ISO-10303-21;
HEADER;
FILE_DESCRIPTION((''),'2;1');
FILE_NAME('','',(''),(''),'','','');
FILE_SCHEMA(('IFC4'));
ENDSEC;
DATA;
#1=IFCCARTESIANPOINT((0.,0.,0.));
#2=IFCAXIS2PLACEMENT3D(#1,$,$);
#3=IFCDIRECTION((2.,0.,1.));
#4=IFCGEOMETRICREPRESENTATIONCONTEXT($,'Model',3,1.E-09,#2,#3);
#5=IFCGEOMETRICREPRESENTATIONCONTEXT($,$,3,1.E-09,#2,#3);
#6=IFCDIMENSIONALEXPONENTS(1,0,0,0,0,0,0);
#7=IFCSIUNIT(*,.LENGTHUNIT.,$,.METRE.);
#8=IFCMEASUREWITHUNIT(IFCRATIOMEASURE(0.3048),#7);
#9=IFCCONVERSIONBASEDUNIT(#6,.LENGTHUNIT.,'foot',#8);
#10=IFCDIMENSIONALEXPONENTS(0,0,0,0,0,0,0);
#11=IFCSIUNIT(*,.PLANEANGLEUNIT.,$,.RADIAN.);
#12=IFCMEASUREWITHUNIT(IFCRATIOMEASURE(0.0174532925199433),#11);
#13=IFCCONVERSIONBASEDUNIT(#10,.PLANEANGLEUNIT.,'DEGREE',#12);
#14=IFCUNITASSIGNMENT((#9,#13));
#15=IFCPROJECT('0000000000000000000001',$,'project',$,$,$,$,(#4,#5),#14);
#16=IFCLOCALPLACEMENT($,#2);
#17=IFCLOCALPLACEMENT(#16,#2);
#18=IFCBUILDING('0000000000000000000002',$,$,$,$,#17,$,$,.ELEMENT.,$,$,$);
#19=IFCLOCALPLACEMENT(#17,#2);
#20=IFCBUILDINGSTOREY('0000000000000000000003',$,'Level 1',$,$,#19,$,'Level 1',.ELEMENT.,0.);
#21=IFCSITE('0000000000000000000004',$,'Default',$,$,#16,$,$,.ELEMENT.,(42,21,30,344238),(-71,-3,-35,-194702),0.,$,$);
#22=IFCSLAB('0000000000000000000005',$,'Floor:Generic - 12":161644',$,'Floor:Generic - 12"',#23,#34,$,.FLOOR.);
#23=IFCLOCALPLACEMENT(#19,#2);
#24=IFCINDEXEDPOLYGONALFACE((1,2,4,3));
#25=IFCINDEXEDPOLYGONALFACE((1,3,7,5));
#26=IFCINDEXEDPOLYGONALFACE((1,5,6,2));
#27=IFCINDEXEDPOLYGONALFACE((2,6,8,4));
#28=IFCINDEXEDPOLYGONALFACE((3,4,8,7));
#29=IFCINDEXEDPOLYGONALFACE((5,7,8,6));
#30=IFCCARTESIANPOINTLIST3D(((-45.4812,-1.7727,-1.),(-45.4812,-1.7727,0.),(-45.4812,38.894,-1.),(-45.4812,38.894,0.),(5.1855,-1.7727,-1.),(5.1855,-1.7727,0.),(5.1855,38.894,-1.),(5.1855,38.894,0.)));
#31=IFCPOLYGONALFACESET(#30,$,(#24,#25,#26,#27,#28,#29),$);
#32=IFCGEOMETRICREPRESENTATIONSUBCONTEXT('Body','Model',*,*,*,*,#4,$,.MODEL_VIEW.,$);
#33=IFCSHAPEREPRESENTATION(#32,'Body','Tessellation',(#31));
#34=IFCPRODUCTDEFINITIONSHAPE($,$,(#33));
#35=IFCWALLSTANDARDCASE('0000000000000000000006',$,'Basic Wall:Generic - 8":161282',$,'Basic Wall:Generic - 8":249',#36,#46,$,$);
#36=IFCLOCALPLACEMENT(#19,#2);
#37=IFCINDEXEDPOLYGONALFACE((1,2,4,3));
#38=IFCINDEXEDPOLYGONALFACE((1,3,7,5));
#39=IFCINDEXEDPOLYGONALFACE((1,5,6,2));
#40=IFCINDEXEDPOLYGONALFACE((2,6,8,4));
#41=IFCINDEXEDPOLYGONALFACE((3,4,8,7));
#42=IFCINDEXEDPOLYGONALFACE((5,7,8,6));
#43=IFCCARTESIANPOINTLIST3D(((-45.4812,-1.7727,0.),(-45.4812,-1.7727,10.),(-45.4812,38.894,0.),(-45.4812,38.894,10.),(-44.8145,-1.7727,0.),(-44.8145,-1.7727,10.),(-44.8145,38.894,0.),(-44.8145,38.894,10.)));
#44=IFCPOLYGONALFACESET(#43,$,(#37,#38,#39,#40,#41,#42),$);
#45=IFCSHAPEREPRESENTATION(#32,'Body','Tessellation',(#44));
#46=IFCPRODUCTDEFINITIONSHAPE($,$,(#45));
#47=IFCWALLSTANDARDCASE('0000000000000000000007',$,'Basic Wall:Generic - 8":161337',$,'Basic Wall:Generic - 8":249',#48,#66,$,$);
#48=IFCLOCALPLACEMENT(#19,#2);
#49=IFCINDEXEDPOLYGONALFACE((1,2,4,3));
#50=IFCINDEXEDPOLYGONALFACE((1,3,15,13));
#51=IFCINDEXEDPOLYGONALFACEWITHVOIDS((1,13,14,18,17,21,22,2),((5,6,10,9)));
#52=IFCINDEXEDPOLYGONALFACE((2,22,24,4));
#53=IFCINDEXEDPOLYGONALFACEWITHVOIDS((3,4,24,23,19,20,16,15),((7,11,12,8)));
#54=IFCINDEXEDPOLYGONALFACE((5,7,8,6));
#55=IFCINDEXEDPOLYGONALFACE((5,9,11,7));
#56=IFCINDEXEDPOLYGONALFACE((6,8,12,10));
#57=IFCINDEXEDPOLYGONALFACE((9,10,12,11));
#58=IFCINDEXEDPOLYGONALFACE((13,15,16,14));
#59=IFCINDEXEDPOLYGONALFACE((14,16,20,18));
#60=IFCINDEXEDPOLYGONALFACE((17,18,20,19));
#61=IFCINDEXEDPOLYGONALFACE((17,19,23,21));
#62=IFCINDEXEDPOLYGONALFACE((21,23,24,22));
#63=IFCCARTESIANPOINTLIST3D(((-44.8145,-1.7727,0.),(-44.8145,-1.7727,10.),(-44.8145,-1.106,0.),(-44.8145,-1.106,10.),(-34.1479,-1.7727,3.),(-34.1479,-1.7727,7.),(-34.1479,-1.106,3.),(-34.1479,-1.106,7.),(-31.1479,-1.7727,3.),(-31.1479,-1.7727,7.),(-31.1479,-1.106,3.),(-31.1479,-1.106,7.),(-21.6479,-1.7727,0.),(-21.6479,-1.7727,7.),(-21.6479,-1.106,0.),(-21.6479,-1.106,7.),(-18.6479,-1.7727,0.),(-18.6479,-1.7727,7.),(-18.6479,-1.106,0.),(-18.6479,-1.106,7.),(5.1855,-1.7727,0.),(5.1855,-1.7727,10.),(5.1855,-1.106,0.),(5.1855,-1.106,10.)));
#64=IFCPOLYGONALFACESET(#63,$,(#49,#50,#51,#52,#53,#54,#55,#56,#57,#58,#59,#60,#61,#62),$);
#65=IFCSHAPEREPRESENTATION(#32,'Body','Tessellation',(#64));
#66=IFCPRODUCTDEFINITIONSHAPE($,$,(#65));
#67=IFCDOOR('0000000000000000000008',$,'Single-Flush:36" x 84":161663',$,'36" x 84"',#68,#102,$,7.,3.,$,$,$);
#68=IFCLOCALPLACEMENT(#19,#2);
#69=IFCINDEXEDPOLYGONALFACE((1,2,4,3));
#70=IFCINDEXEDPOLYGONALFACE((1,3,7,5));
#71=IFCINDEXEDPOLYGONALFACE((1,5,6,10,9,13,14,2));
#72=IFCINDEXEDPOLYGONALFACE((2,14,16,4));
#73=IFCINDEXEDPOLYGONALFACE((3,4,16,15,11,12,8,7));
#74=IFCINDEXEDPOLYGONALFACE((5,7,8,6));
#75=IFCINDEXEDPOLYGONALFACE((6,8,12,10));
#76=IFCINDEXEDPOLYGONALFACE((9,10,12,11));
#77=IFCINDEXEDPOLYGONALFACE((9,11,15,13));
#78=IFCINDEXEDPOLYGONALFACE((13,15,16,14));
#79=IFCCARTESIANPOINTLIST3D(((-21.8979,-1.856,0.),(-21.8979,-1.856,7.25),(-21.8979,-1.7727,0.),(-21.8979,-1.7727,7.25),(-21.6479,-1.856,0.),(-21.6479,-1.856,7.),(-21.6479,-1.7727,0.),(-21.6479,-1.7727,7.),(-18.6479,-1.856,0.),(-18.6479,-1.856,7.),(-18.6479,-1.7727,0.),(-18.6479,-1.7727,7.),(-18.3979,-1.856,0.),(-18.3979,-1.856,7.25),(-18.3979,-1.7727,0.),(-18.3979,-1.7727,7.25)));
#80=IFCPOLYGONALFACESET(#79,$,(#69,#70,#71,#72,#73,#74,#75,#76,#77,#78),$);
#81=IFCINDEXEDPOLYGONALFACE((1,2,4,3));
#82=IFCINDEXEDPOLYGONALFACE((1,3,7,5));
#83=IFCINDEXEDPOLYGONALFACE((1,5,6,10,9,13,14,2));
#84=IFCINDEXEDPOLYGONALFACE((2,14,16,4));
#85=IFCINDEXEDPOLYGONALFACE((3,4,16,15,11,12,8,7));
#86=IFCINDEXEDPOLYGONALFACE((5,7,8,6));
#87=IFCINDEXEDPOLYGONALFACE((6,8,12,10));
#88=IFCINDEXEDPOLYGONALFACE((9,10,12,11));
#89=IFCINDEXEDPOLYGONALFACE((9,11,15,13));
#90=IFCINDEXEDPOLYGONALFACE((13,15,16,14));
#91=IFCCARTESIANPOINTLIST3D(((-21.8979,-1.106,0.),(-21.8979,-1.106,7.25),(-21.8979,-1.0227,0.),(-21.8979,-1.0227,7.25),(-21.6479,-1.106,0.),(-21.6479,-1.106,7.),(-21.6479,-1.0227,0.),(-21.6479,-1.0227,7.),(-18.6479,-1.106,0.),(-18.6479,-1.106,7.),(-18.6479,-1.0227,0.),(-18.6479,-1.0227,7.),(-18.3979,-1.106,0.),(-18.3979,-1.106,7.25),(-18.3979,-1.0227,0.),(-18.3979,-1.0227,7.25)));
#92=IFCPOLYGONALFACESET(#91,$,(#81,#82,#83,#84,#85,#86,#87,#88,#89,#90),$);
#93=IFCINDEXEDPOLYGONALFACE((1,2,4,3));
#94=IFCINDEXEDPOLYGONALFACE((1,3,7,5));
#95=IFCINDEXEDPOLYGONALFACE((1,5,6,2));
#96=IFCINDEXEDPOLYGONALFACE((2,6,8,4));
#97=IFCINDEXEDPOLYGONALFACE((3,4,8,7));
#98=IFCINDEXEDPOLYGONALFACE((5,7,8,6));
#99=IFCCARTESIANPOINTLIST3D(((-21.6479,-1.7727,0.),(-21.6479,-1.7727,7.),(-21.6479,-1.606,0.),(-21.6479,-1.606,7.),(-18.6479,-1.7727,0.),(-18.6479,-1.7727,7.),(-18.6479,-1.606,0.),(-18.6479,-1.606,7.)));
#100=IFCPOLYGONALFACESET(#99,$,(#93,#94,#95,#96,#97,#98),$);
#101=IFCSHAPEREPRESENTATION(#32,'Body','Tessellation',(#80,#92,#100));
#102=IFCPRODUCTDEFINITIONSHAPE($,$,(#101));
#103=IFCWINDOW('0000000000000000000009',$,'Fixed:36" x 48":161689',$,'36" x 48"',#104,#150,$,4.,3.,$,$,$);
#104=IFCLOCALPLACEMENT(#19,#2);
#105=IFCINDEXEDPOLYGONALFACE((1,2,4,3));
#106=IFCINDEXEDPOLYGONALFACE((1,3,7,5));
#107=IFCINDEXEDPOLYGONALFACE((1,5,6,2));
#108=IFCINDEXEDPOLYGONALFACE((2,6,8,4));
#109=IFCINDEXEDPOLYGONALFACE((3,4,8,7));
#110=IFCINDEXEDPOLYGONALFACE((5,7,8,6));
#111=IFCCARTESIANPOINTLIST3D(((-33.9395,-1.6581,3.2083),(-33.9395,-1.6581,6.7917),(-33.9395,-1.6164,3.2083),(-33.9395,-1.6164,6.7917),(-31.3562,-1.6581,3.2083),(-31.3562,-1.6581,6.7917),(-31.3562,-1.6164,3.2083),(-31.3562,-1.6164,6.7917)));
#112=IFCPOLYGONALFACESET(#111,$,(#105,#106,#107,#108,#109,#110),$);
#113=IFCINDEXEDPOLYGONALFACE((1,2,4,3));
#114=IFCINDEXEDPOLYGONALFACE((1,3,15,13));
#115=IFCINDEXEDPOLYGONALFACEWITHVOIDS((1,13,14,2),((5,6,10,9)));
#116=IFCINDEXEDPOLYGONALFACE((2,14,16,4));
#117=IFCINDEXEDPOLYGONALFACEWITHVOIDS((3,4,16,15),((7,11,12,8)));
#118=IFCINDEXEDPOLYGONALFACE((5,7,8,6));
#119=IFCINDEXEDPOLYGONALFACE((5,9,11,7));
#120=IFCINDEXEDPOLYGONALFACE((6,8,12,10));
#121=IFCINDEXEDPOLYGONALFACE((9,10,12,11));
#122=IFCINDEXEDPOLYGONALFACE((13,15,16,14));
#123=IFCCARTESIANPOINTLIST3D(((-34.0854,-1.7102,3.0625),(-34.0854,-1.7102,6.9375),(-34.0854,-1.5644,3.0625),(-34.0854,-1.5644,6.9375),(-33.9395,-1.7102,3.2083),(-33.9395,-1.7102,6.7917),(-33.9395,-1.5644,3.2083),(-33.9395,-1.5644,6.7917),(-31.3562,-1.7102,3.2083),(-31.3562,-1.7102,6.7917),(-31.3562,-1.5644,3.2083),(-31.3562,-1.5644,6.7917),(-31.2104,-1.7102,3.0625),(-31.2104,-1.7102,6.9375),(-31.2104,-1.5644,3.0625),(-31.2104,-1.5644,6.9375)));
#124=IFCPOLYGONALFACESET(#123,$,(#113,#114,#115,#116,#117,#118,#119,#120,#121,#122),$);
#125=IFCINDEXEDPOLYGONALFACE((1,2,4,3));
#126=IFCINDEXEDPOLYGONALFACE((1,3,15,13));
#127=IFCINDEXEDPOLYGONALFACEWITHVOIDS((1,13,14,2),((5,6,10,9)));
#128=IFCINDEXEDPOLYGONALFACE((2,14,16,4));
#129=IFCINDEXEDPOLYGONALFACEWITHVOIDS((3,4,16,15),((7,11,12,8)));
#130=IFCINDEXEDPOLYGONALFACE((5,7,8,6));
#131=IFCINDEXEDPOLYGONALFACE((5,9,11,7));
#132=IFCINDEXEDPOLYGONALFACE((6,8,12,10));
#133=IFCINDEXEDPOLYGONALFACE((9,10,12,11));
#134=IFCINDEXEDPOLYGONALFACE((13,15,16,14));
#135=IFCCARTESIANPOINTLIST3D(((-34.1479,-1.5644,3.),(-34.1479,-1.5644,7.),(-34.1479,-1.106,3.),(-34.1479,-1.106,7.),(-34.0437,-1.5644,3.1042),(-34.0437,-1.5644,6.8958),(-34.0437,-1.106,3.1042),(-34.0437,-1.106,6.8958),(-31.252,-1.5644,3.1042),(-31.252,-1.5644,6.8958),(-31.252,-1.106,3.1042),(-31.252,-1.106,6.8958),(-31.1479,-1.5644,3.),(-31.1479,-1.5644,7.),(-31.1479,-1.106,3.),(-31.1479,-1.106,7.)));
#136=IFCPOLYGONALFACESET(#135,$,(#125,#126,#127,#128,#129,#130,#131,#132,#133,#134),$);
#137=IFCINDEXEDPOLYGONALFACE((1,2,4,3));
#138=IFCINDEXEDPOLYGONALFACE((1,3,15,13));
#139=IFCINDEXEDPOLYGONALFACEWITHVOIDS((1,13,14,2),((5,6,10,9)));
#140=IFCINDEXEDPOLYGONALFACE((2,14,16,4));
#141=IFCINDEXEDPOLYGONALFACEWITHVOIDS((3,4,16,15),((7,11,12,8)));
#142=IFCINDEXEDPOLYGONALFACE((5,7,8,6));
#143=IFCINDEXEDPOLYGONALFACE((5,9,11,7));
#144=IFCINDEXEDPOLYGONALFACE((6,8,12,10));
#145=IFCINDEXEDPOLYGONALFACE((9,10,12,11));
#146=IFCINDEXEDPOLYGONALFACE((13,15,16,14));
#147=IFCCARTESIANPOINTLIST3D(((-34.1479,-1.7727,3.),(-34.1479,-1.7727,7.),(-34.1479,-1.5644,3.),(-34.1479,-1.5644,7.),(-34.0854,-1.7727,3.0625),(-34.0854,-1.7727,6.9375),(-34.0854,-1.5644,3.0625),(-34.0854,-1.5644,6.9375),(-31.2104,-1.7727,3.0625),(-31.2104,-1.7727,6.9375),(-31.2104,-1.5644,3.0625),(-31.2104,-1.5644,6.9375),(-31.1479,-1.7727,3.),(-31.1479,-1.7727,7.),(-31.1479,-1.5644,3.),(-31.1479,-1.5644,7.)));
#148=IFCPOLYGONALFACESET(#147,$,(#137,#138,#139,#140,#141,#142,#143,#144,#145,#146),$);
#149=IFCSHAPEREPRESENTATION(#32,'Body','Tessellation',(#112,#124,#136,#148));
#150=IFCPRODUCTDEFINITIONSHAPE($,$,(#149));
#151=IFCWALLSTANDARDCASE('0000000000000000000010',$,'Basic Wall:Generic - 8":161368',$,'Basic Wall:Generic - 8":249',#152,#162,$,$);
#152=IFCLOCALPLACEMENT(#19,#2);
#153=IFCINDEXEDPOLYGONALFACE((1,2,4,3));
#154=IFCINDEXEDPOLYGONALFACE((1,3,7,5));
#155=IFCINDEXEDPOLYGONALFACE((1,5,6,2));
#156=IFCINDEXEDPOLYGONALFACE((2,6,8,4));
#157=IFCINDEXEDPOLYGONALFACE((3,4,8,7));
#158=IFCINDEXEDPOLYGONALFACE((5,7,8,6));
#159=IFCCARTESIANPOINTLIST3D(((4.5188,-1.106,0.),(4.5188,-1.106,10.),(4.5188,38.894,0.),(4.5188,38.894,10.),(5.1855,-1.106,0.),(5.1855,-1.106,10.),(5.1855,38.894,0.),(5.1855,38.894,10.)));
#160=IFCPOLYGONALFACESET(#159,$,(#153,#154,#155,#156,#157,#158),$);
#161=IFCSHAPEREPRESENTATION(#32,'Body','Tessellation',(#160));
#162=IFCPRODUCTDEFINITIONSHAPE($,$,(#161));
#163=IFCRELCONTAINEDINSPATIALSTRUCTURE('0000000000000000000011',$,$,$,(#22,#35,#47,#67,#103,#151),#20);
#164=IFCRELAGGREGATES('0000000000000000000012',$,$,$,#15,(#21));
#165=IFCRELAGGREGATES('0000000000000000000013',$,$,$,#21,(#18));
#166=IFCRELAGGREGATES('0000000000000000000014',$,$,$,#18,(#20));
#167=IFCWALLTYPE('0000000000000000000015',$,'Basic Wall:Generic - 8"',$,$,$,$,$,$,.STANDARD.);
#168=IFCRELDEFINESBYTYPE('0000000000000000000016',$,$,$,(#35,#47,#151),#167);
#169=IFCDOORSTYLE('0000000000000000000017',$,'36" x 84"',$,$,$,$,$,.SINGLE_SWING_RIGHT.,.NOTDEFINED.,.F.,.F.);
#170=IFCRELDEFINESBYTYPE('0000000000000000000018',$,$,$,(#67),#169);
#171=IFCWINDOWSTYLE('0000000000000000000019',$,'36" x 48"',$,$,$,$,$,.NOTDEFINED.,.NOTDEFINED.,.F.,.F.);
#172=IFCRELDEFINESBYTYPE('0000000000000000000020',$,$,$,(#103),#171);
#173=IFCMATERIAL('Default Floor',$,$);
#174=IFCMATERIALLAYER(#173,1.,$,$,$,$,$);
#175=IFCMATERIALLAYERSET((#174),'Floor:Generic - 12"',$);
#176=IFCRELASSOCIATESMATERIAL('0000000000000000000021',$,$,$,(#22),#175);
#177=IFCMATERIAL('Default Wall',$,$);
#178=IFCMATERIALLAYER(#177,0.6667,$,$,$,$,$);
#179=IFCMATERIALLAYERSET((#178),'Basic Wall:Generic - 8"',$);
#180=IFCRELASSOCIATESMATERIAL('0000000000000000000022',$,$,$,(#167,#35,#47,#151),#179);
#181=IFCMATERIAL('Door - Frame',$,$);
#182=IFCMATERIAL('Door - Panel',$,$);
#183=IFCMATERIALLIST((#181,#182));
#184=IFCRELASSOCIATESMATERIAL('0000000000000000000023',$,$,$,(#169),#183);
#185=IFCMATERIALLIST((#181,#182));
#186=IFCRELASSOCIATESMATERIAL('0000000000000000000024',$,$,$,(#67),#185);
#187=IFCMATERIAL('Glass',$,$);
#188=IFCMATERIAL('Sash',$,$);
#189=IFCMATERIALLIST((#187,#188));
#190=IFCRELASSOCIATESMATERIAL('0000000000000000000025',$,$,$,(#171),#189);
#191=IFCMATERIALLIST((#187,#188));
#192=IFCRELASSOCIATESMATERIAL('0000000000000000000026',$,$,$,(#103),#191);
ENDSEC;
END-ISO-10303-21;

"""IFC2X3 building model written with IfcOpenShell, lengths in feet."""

from ifc_helpers import new_model, entity, si_unit, converted_unit, direction, frame, frame_2d, origin, place, context, subcontext, project, spatial, polyline, rectangle, outline, extrude, clip, bounded_halfspace, source, transform, mapped, material, material_list, layer, layer_set, layer_usage, type_object, type_shapes, element, fill, save


model = new_model("IFC2X3")

# Units and contexts
model_context = context("Model", 3, precision=1e-09, world=origin(), true_north=direction((2.0, 0.0, 1.0)))
context_of_model = context(None, 3, precision=1e-09, world=origin(), true_north=direction((2.0, 0.0, 1.0)))
body_context = subcontext(model_context, "Body", "Model", "MODEL_VIEW")
ifc_project = project(units=[converted_unit("LENGTHUNIT", "foot", entity("IfcRatioMeasure", 0.3048), si_unit("LENGTHUNIT", "METRE"), dimensions=[1, 0, 0, 0, 0, 0, 0]), converted_unit("PLANEANGLEUNIT", "DEGREE", entity("IfcRatioMeasure", 0.0174532925199433), si_unit("PLANEANGLEUNIT", "RADIAN"), dimensions=[0, 0, 0, 0, 0, 0, 0])], contexts=[model_context, context_of_model])

# Site, building, storey
site_placement = place(None, origin())
site = spatial("IfcSite", under=ifc_project, at=site_placement, Name="Default", CompositionType="ELEMENT", RefLatitude=(42, 21, 30, 344238), RefLongitude=(-71, -3, -35, -194702), RefElevation=0.0)
building_placement = place(site_placement, origin())
building = spatial("IfcBuilding", under=site, at=building_placement, CompositionType="ELEMENT")
storey_placement = place(building_placement, origin())
storey = spatial("IfcBuildingStorey", under=building, at=storey_placement, Name="Level 1", LongName="Level 1", CompositionType="ELEMENT", Elevation=0.0)

# Slab
ifc_material_1 = material(Name="Default Floor")
ifc_layer_1 = layer(ifc_material_1, 1.0)
ifc_layer_set_1 = layer_set([ifc_layer_1], Name="Floor:Generic - 12\"")
ifc_layer_usage_1 = layer_usage(ifc_layer_set_1, "AXIS3", "POSITIVE", 0.0)
slab_placement = place(storey_placement, origin())
element("IfcSlab", 1, at=slab_placement, inside=storey, material=ifc_layer_usage_1, Name="Floor:Generic - 12\":161644", ObjectType="Floor:Generic - 12\"", PredefinedType="FLOOR", context=body_context, shape_type="SweptSolid", body=[
    extrude(rectangle(XDim=40.6667, YDim=50.6667, at=frame_2d((0.0, 0.0), x_axis=(1.0, 0.0))), frame((-20.1479, 18.5606, 0.0), z_axis=(0.0, 0.0, -1.0), x_axis=(0.0, 1.0, 0.0)), (0.0, 0.0, 1.0), 1.0),
])

# Wall
ifc_material_2 = material(Name="Default Wall")
ifc_layer_2 = layer(ifc_material_2, 0.6667)
ifc_layer_set_2 = layer_set([ifc_layer_2], Name="Basic Wall:Generic - 8\"")
ifc_layer_usage_2 = layer_usage(ifc_layer_set_2, "AXIS2", "NEGATIVE", 0.3333)
wall_type = type_object("IfcWallType", Name="Basic Wall:Generic - 8\"", PredefinedType="STANDARD", material=ifc_layer_set_2)
wall_1_placement = place(storey_placement, frame((-45.1479, 38.894, 0.0), z_axis=(0.0, 0.0, 1.0), x_axis=(0.0, -1.0, 0.0)))
element("IfcWallStandardCase", 2, at=wall_1_placement, inside=storey, type_object=wall_type, material=ifc_layer_usage_2, Name="Basic Wall:Generic - 8\":161282", ObjectType="Basic Wall:Generic - 8\":249", context=body_context, shape_type="Clipping", body=[
    clip(extrude(rectangle(XDim=40.6667, YDim=0.6667, at=frame_2d((20.3333, 0.0), x_axis=(-1.0, 0.0))), origin(), (0.0, 0.0, 1.0), 10.0), bounded_halfspace(frame((0.0, -0.3333, 10.0), z_axis=(0.0, 0.0, 1.0), x_axis=(0.0, 1.0, 0.0)), False, frame((0.0, -0.3333, 10.0)), polyline([(0.0, 0.0), (40.6667, 0.0), (40.6667, 0.6667), (40.0, 0.6667), (0.6667, 0.6667), (0.0, 0.6667), (0.0, 0.0)]))),
])

# Wall, openings, door, window
ifc_layer_usage_3 = layer_usage(ifc_layer_set_2, "AXIS2", "NEGATIVE", 0.3333)
wall_2_placement = place(storey_placement, frame((-44.8145, -1.4394, 0.0)))
wall_2 = element("IfcWallStandardCase", 3, at=wall_2_placement, inside=storey, type_object=wall_type, material=ifc_layer_usage_3, Name="Basic Wall:Generic - 8\":161337", ObjectType="Basic Wall:Generic - 8\":249", context=body_context, shape_type="Clipping", body=[
    clip(extrude(rectangle(XDim=50.0, YDim=0.6667, at=frame_2d((25.0, 0.0), x_axis=(-1.0, 0.0))), origin(), (0.0, 0.0, 1.0), 10.0), bounded_halfspace(frame((0.0, -0.3333, 10.0)), False, frame((0.0, -0.3333, 10.0)), polyline([(0.0, 0.0), (50.0, 0.0), (50.0, 0.6667), (49.3333, 0.6667), (30.0, 0.6667), (29.3333, 0.6667), (0.0, 0.6667), (0.0, 0.0)]))),
])
opening_1_placement = place(wall_2_placement, frame((26.1667, 0.3333, 0.0)))
opening_1 = element("IfcOpeningElement", 4, at=opening_1_placement, cuts=wall_2, ObjectType="Opening", context=body_context, shape_type="SweptSolid", body=[
    extrude(rectangle(XDim=3.0, YDim=7.0, at=frame_2d((3.5, 1.5), x_axis=(0.0, 1.0))), frame((0.0, 0.0, 0.0), z_axis=(0.0, -1.0, 0.0), x_axis=(0.0, 0.0, 1.0)), (0.0, 0.0, 1.0), 0.6667),
])
opening_2_placement = place(wall_2_placement, frame((13.6667, 0.3333, 3.0)))
opening_2 = element("IfcOpeningElement", 5, at=opening_2_placement, cuts=wall_2, ObjectType="Opening", context=body_context, shape_type="SweptSolid", body=[
    extrude(rectangle(XDim=4.0, YDim=3.0, at=frame_2d((2.0, 1.5), x_axis=(-1.0, 0.0))), frame((0.0, 0.0, 0.0), z_axis=(0.0, -1.0, 0.0), x_axis=(0.0, 0.0, 1.0)), (0.0, 0.0, 1.0), 0.6667),
])
ifc_material_3 = material(Name="Door - Frame")
ifc_material_4 = material(Name="Door - Panel")
ifc_material_list_1 = material_list([ifc_material_3, ifc_material_4])
ifc_material_list_2 = material_list([ifc_material_3, ifc_material_4])
door_style = type_object("IfcDoorStyle", Name="36\" x 84\"", ConstructionType="NOTDEFINED", OperationType="SINGLE_SWING_RIGHT", ParameterTakesPrecedence=False, Sizeable=False, material=ifc_material_list_2)
shared_shape_1 = source(origin(), body_context, "Body", "SweptSolid", [
    extrude(outline(polyline([(-1.75, -3.6875), (1.75, -3.6875), (1.75, 3.5625), (1.5, 3.5625), (1.5, -3.4375), (-1.5, -3.4375), (-1.5, 3.5625), (-1.75, 3.5625), (-1.75, -3.6875)])), frame((1.5, 0.6667, 3.5625), z_axis=(0.0, 1.0, 0.0), x_axis=(1.0, 0.0, 0.0)), (0.0, 0.0, 1.0), 0.0833),
    extrude(outline(polyline([(-3.6875, -1.75), (3.5625, -1.75), (3.5625, -1.5), (-3.4375, -1.5), (-3.4375, 1.5), (3.5625, 1.5), (3.5625, 1.75), (-3.6875, 1.75), (-3.6875, -1.75)])), frame((1.5, -0.0833, 3.5625), z_axis=(0.0, 1.0, 0.0), x_axis=(0.0, 0.0, -1.0)), (0.0, 0.0, 1.0), 0.0833),
    extrude(rectangle(XDim=0.1667, YDim=3.0, at=frame_2d((0.0, 0.0), x_axis=(1.0, 0.0))), frame((1.5, 0.5833, 0.0), z_axis=(0.0, 0.0, 1.0), x_axis=(0.0, 1.0, 0.0)), (0.0, 0.0, 1.0), 7.0),
])
type_shapes(door_style, [shared_shape_1])
door_1_placement = place(storey_placement, frame((-18.6479, -1.106, 0.0), z_axis=(0.0, 0.0, 1.0), x_axis=(-1.0, 0.0, 0.0)))
door_1 = element("IfcDoor", 6, at=door_1_placement, inside=storey, type_object=door_style, material=ifc_material_list_1, Name="Single-Flush:36\" x 84\":161663", ObjectType="36\" x 84\"", OverallHeight=7.0, OverallWidth=3.0, context=body_context, shape_type="MappedRepresentation", body=[
    mapped(shared_shape_1, transform((0.0, 0.0, 0.0), scale=1.0)),
])
fill(opening_1, door_1)
ifc_material_5 = material(Name="Glass")
ifc_material_6 = material(Name="Sash")
ifc_material_list_3 = material_list([ifc_material_5, ifc_material_6])
ifc_material_list_4 = material_list([ifc_material_5, ifc_material_6])
window_style = type_object("IfcWindowStyle", Name="36\" x 48\"", ConstructionType="NOTDEFINED", OperationType="NOTDEFINED", ParameterTakesPrecedence=False, Sizeable=False, material=ifc_material_list_4)
shared_shape_2 = source(origin(), body_context, "Body", "SweptSolid", [
    extrude(rectangle(XDim=0.0417, YDim=2.5833, at=frame_2d((0.0, 0.0), x_axis=(1.0, 0.0))), frame((1.5, 0.5312, 0.2083), z_axis=(0.0, 0.0, 1.0), x_axis=(0.0, 1.0, 0.0)), (0.0, 0.0, 1.0), 3.5833),
    extrude(outline(polyline([(-1.4375, -1.9375), (1.4375, -1.9375), (1.4375, 1.9375), (-1.4375, 1.9375), (-1.4375, -1.9375)]), holes=[polyline([(-1.2917, -1.7917), (-1.2917, 1.7917), (1.2917, 1.7917), (1.2917, -1.7917), (-1.2917, -1.7917)])]), frame((1.5, 0.4583, 2.0), z_axis=(0.0, 1.0, 0.0), x_axis=(1.0, 0.0, 0.0)), (0.0, 0.0, 1.0), 0.1458),
    extrude(outline(polyline([(-1.5, -2.0), (1.5, -2.0), (1.5, 2.0), (-1.5, 2.0), (-1.5, -2.0)]), holes=[polyline([(-1.3958, -1.8958), (-1.3958, 1.8958), (1.3958, 1.8958), (1.3958, -1.8958), (-1.3958, -1.8958)])]), frame((1.5, 0.0, 2.0), z_axis=(0.0, 1.0, 0.0), x_axis=(1.0, 0.0, 0.0)), (0.0, 0.0, 1.0), 0.4583),
    extrude(outline(polyline([(-2.0, -1.5), (2.0, -1.5), (2.0, 1.5), (-2.0, 1.5), (-2.0, -1.5)]), holes=[polyline([(-1.9375, -1.4375), (-1.9375, 1.4375), (1.9375, 1.4375), (1.9375, -1.4375), (-1.9375, -1.4375)])]), frame((1.5, 0.4583, 2.0), z_axis=(0.0, 1.0, 0.0), x_axis=(0.0, 0.0, -1.0)), (0.0, 0.0, 1.0), 0.2083),
])
type_shapes(window_style, [shared_shape_2])
window_placement = place(storey_placement, frame((-31.1479, -1.106, 3.0), z_axis=(0.0, 0.0, 1.0), x_axis=(-1.0, 0.0, 0.0)))
window = element("IfcWindow", 7, at=window_placement, inside=storey, type_object=window_style, material=ifc_material_list_3, Name="Fixed:36\" x 48\":161689", ObjectType="36\" x 48\"", OverallHeight=4.0, OverallWidth=3.0, context=body_context, shape_type="MappedRepresentation", body=[
    mapped(shared_shape_2, transform((0.0, 0.0, 0.0), scale=1.0)),
])
fill(opening_2, window)

# Wall
ifc_layer_usage_4 = layer_usage(ifc_layer_set_2, "AXIS2", "NEGATIVE", 0.3333)
wall_3_placement = place(storey_placement, frame((4.8521, -1.106, 0.0), z_axis=(0.0, 0.0, 1.0), x_axis=(0.0, 1.0, 0.0)))
element("IfcWallStandardCase", 8, at=wall_3_placement, inside=storey, type_object=wall_type, material=ifc_layer_usage_4, Name="Basic Wall:Generic - 8\":161368", ObjectType="Basic Wall:Generic - 8\":249", context=body_context, shape_type="Clipping", body=[
    clip(extrude(rectangle(XDim=40.0, YDim=0.6667, at=frame_2d((20.0, 0.0), x_axis=(-1.0, 0.0))), origin(), (0.0, 0.0, 1.0), 10.0), bounded_halfspace(frame((0.0, -0.3333, 10.0), z_axis=(0.0, 0.0, 1.0), x_axis=(0.0, -1.0, 0.0)), False, frame((0.0, -0.3333, 10.0)), polyline([(0.0, 0.0), (40.0, 0.0), (40.0, 0.6667), (39.3333, 0.6667), (0.0, 0.6667), (0.0, 0.0)]))),
])

save(model, "model.ifc")
